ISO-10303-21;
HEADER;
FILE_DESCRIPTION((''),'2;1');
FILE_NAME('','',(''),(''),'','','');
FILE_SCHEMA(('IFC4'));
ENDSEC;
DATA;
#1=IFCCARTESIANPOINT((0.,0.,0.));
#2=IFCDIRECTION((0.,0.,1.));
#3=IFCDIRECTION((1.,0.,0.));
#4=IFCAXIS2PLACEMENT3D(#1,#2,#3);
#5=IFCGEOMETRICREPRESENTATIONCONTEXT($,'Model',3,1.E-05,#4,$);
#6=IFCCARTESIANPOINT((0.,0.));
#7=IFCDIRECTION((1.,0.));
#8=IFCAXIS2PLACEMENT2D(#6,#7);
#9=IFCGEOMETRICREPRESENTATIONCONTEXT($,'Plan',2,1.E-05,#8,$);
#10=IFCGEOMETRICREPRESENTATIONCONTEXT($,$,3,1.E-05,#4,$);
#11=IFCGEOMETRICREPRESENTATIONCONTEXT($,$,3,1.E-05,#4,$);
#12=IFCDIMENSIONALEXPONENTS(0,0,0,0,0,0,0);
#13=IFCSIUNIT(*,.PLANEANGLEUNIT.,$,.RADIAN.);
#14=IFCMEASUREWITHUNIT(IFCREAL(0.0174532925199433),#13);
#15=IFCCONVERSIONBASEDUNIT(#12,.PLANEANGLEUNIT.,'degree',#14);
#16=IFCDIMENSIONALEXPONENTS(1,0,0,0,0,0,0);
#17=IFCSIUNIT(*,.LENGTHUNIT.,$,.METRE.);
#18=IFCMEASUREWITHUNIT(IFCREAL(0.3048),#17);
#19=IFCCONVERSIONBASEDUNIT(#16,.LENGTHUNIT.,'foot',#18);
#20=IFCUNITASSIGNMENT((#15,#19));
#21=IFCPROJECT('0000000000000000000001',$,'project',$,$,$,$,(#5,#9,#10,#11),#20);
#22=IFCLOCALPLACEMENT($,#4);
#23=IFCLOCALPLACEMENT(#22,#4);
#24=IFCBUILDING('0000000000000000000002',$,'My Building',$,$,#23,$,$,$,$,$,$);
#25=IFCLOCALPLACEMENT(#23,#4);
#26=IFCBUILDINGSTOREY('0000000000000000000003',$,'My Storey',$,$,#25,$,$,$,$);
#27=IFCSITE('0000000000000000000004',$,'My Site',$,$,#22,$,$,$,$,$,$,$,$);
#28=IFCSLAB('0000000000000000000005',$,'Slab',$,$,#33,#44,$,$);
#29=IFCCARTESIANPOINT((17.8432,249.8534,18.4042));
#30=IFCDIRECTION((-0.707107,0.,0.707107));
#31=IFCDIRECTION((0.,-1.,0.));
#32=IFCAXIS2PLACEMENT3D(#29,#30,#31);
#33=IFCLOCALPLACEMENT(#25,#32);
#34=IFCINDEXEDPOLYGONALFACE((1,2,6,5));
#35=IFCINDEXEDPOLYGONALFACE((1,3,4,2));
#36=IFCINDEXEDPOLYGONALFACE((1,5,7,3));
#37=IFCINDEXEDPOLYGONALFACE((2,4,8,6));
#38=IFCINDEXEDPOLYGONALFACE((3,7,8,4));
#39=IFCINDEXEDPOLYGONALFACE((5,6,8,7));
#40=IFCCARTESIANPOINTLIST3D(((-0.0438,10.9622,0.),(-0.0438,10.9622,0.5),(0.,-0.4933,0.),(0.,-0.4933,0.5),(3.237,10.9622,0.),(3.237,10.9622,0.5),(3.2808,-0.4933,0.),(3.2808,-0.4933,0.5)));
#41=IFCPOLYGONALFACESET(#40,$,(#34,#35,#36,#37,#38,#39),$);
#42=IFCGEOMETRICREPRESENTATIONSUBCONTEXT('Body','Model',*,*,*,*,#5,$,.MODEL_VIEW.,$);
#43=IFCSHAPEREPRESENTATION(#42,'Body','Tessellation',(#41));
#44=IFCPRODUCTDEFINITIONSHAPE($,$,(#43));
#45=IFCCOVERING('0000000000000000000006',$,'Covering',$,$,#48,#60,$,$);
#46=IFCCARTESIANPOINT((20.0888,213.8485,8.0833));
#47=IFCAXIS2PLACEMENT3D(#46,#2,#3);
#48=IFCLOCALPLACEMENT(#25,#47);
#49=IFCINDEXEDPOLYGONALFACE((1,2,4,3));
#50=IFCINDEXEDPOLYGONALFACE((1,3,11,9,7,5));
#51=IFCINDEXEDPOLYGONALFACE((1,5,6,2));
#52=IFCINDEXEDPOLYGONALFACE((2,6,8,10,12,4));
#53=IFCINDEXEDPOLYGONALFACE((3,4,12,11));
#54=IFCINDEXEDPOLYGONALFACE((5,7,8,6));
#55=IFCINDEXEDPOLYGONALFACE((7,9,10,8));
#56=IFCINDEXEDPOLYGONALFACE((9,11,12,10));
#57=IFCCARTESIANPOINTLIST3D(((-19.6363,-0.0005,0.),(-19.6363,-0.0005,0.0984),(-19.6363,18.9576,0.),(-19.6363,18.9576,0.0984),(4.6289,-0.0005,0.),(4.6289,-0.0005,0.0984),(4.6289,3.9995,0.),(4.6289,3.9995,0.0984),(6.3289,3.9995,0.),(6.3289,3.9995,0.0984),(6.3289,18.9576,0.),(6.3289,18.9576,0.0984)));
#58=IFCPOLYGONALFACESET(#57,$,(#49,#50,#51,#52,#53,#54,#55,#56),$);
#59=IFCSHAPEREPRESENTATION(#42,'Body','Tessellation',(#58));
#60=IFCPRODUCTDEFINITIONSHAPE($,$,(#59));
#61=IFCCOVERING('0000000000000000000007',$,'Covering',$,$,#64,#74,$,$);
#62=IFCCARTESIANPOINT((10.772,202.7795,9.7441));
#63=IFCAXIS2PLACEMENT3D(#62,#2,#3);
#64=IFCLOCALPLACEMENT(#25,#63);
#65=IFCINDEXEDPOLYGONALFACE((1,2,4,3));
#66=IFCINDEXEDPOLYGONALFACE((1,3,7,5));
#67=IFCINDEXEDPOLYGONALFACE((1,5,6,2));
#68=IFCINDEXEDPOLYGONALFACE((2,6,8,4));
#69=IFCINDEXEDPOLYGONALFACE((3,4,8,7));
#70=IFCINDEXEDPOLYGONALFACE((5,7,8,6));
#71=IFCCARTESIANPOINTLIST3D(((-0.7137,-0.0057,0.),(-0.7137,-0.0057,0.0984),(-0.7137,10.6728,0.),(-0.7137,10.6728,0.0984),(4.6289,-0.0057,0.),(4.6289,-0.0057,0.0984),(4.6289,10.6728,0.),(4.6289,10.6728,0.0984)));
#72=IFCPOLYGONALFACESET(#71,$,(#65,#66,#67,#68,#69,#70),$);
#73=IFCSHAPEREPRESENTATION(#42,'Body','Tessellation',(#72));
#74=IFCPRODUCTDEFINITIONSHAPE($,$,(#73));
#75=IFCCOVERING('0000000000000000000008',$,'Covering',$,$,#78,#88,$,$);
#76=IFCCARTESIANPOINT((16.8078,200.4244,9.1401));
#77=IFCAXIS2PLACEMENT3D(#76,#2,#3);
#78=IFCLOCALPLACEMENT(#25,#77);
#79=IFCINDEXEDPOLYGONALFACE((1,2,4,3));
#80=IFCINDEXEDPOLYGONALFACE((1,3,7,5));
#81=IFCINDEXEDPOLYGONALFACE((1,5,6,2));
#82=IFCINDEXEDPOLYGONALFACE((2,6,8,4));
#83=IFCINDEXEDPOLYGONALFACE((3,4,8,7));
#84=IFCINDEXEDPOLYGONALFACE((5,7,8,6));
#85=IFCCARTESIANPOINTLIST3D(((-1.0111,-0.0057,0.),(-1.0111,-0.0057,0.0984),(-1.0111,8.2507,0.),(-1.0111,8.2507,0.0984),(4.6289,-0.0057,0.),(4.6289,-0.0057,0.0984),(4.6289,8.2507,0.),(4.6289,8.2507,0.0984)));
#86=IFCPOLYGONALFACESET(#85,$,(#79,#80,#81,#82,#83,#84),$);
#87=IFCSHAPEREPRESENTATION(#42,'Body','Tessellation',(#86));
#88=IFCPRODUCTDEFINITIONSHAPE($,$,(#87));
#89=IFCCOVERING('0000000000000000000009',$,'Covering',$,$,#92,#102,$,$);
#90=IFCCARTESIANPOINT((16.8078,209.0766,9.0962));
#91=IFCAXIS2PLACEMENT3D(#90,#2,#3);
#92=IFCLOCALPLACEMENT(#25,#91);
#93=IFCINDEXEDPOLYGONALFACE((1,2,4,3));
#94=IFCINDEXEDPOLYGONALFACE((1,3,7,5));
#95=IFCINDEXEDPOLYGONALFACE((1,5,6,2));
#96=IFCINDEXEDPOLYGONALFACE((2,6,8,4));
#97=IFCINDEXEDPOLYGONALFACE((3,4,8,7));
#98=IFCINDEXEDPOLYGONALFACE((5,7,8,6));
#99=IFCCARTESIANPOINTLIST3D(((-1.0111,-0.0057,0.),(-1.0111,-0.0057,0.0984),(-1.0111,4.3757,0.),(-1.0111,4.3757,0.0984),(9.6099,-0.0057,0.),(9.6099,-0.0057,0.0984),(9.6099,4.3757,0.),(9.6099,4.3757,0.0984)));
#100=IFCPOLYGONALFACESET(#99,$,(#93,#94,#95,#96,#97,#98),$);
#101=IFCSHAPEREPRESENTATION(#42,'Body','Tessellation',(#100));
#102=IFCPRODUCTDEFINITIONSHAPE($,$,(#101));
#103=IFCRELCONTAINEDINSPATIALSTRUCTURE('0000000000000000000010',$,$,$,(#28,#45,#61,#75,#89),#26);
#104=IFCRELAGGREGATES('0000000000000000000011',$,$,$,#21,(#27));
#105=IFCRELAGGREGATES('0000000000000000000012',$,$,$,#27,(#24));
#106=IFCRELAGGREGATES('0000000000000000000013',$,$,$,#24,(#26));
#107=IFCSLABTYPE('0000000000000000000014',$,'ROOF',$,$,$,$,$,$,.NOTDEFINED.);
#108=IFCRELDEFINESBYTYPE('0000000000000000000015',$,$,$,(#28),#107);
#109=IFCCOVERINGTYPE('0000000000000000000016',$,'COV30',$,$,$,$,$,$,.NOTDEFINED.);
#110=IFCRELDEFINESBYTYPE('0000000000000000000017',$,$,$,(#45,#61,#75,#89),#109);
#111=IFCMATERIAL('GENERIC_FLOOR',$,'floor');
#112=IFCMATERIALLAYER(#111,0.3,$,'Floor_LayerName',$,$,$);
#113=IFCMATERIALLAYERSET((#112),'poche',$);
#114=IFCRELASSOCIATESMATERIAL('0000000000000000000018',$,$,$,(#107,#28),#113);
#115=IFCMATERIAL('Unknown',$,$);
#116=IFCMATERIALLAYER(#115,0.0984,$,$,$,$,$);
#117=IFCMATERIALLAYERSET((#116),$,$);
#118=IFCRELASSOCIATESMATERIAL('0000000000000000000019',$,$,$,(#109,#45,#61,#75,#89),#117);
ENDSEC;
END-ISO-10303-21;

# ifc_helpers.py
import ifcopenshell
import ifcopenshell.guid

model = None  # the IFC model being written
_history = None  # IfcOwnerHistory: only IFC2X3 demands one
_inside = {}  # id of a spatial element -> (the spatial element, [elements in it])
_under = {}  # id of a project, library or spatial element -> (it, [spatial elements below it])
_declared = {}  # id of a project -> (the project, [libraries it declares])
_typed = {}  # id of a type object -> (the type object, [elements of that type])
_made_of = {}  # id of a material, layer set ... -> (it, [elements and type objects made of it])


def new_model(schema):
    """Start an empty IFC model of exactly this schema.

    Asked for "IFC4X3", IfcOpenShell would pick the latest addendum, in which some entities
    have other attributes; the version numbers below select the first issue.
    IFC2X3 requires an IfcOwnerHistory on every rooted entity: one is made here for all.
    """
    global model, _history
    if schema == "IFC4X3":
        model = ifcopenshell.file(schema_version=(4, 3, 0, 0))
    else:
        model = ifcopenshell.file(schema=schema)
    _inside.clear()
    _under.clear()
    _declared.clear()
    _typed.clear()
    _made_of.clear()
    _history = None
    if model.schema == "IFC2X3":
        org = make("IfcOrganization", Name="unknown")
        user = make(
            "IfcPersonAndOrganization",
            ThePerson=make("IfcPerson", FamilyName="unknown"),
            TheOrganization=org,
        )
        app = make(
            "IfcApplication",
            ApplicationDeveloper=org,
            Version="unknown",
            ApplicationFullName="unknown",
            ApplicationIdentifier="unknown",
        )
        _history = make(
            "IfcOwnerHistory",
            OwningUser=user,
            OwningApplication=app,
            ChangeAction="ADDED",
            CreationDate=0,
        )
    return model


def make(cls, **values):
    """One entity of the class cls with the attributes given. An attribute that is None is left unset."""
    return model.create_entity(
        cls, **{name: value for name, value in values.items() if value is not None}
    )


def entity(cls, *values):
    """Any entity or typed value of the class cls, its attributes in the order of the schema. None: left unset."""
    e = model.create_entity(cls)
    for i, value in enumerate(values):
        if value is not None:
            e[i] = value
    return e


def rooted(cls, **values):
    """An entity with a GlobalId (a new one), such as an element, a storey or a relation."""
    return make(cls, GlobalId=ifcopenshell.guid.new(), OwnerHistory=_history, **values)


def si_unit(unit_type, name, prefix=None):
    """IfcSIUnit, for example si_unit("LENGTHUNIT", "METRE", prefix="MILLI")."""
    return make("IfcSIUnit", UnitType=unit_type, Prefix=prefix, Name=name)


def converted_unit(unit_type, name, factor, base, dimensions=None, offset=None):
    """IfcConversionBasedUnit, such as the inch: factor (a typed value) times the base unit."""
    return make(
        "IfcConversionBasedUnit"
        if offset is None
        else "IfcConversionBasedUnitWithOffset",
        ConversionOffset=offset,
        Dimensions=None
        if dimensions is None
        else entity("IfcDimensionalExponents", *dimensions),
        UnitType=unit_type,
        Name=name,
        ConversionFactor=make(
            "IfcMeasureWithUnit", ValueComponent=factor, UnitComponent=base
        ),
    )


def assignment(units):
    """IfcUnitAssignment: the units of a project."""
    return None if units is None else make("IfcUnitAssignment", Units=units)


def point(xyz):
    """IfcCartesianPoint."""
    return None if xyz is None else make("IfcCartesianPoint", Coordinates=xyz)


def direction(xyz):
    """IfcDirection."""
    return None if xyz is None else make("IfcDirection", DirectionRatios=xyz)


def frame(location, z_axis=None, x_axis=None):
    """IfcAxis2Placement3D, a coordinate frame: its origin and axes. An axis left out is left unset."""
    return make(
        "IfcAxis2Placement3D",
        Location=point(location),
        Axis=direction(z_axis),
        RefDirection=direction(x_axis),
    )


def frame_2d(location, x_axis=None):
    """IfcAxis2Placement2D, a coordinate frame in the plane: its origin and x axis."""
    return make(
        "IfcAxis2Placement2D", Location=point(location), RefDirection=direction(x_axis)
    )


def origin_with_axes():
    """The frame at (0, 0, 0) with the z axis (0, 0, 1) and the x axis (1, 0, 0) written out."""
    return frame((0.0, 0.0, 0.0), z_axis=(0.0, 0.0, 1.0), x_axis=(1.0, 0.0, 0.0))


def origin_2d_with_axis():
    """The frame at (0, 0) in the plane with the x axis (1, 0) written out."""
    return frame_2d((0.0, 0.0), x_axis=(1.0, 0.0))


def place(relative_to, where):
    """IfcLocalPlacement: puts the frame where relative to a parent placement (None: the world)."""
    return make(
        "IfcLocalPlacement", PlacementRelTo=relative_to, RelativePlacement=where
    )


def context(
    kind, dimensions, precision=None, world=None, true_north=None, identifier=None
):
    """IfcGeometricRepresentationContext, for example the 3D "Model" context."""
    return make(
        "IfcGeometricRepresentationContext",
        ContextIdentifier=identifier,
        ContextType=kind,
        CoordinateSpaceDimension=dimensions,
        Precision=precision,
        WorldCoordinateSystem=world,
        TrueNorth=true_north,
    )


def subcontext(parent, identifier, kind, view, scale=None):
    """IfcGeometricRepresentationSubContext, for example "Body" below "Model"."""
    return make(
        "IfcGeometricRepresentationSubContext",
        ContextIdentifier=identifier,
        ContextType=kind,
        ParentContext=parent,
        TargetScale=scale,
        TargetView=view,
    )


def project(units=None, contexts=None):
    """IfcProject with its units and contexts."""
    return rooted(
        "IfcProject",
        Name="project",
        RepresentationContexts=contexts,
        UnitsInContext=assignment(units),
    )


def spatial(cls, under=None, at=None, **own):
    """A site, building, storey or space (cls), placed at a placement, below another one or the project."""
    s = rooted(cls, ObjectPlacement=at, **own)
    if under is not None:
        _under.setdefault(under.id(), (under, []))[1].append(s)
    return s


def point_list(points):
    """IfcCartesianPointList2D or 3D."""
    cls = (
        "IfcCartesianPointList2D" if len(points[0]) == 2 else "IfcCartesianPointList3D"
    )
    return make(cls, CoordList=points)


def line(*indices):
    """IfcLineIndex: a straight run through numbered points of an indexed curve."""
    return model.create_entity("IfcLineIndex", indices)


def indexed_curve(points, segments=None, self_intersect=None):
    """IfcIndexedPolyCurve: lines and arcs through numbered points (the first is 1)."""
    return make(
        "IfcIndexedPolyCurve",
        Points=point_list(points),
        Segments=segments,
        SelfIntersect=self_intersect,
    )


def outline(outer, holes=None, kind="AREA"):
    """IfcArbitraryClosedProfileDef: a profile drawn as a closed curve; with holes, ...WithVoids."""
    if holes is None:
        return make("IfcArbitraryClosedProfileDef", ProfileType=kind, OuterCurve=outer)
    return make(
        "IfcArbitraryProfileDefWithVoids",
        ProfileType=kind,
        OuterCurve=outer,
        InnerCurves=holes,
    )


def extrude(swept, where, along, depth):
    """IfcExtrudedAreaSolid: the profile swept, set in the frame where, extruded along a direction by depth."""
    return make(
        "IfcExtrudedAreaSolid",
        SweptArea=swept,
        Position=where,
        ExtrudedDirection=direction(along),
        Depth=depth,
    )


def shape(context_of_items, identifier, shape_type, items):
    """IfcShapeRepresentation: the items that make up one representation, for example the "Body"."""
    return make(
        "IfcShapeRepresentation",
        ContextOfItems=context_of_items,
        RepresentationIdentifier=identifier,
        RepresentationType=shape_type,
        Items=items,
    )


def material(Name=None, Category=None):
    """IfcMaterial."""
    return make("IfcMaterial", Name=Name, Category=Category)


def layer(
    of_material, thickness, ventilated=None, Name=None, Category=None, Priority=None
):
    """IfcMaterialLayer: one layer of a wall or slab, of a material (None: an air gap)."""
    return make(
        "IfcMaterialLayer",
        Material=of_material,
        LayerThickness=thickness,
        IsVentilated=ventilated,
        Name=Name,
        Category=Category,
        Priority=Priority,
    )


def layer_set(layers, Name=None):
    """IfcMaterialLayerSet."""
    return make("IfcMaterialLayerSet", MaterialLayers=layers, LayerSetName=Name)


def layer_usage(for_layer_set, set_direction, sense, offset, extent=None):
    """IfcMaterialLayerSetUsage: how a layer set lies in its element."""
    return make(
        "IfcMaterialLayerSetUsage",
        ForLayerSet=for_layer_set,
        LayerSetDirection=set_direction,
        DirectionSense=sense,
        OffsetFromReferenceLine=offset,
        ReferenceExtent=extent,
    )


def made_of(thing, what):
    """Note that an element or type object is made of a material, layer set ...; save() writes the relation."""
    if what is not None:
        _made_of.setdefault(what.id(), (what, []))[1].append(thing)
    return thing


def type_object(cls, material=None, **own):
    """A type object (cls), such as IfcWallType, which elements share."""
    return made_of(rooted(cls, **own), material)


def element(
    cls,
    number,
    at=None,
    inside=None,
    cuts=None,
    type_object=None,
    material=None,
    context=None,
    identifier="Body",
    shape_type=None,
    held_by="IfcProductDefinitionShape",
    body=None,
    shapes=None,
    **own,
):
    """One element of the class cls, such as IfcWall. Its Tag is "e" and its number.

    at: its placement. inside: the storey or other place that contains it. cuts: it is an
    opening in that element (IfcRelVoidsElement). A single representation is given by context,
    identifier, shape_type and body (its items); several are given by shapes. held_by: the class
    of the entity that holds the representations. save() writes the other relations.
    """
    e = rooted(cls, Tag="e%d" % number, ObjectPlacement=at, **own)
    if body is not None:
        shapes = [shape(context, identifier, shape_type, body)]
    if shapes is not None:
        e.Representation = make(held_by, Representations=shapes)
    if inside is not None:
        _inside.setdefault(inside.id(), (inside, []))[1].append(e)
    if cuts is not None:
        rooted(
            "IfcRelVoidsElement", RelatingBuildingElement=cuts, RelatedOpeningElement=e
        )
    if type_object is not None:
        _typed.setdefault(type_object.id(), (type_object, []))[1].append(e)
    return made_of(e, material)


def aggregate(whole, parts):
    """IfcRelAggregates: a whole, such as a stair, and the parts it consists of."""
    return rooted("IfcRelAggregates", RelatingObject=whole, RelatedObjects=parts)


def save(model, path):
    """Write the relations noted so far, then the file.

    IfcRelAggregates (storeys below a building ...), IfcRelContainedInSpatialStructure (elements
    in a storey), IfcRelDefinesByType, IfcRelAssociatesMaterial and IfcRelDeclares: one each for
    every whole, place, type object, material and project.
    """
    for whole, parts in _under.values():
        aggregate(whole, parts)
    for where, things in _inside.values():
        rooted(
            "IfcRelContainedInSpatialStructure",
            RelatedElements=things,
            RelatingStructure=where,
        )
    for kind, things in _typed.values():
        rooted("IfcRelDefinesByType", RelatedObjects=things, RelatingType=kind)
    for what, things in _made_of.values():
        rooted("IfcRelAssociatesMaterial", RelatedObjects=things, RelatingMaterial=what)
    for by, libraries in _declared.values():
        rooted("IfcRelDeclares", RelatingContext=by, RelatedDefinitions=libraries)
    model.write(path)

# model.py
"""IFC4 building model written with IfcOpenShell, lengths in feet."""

from ifc_helpers import new_model, entity, si_unit, converted_unit, frame, origin_with_axes, origin_2d_with_axis, place, context, subcontext, project, spatial, line, indexed_curve, outline, extrude, material, layer, layer_set, layer_usage, type_object, element, save


model = new_model("IFC4")

# Units and contexts
model_context = context("Model", 3, precision=1e-05, world=origin_with_axes())
plan_context = context("Plan", 2, precision=1e-05, world=origin_2d_with_axis())
context_of_model_1 = context(None, 3, precision=1e-05, world=origin_with_axes())
context_of_model_2 = context(None, 3, precision=1e-05, world=origin_with_axes())
body_context = subcontext(model_context, "Body", "Model", "MODEL_VIEW")
ifc_project = project(units=[converted_unit("PLANEANGLEUNIT", "degree", entity("IfcReal", 0.0174532925199433), si_unit("PLANEANGLEUNIT", "RADIAN"), dimensions=[0, 0, 0, 0, 0, 0, 0]), converted_unit("LENGTHUNIT", "foot", entity("IfcReal", 0.3048), si_unit("LENGTHUNIT", "METRE"), dimensions=[1, 0, 0, 0, 0, 0, 0])], contexts=[model_context, plan_context, context_of_model_1, context_of_model_2])

# Site, building, storey
site_placement = place(None, origin_with_axes())
site = spatial("IfcSite", under=ifc_project, at=site_placement, Name="My Site")
building_placement = place(site_placement, origin_with_axes())
building = spatial("IfcBuilding", under=site, at=building_placement, Name="My Building")
storey_placement = place(building_placement, origin_with_axes())
storey = spatial("IfcBuildingStorey", under=building, at=storey_placement, Name="My Storey")

# Slab
ifc_material_1 = material(Name="GENERIC_FLOOR", Category="floor")
ifc_layer_1 = layer(ifc_material_1, 0.3, Name="Floor_LayerName")
ifc_layer_set_1 = layer_set([ifc_layer_1], Name="poche")
ifc_layer_usage_1 = layer_usage(ifc_layer_set_1, "AXIS3", "POSITIVE", 0.0)
slab_type = type_object("IfcSlabType", Name="ROOF", PredefinedType="NOTDEFINED", material=ifc_layer_set_1)
slab_placement = place(storey_placement, frame((17.8432, 249.8534, 18.4042), z_axis=(-0.707107, 0.0, 0.707107), x_axis=(0.0, -1.0, 0.0)))
element("IfcSlab", 1, at=slab_placement, inside=storey, type_object=slab_type, material=ifc_layer_usage_1, Name="Slab", context=body_context, shape_type="SweptSolid", body=[
    extrude(outline(indexed_curve([(3.237, 10.9622), (-0.0438, 10.9622), (0.0, -0.4933), (3.2808, -0.4933)], segments=[line(4, 1), line(1, 2), line(2, 3), line(3, 4)], self_intersect=False)), None, (0.0, 0.0, 1.0), 0.5),
])

# Coverings
ifc_material_2 = material(Name="Unknown")
ifc_layer_2 = layer(ifc_material_2, 0.0984)
ifc_layer_set_2 = layer_set([ifc_layer_2])
ifc_layer_usage_2 = layer_usage(ifc_layer_set_2, "AXIS3", "POSITIVE", 0.0)
covering_type = type_object("IfcCoveringType", Name="COV30", PredefinedType="NOTDEFINED", material=ifc_layer_set_2)
covering_1_placement = place(storey_placement, frame((20.0888, 213.8485, 8.0833), z_axis=(0.0, 0.0, 1.0), x_axis=(1.0, 0.0, 0.0)))
element("IfcCovering", 2, at=covering_1_placement, inside=storey, type_object=covering_type, material=ifc_layer_usage_2, Name="Covering", context=body_context, shape_type="SweptSolid", body=[
    extrude(outline(indexed_curve([(6.3289, 3.9995), (6.3289, 18.9576), (-19.6363, 18.9576), (-19.6363, -0.0005), (4.6289, -0.0005), (4.6289, 3.9995)], segments=[line(5, 4), line(4, 3), line(3, 2), line(2, 1), line(1, 6), line(6, 5)], self_intersect=False)), None, (0.0, 0.0, 1.0), 0.0984),
])
ifc_layer_usage_3 = layer_usage(ifc_layer_set_2, "AXIS3", "POSITIVE", 0.0)
covering_2_placement = place(storey_placement, frame((10.772, 202.7795, 9.7441), z_axis=(0.0, 0.0, 1.0), x_axis=(1.0, 0.0, 0.0)))
element("IfcCovering", 3, at=covering_2_placement, inside=storey, type_object=covering_type, material=ifc_layer_usage_3, Name="Covering", context=body_context, shape_type="SweptSolid", body=[
    extrude(outline(indexed_curve([(4.6289, -0.0057), (4.6289, 10.6728), (-0.7137, 10.6728), (-0.7137, -0.0057)], segments=[line(3, 2), line(2, 1), line(1, 4), line(4, 3)], self_intersect=False)), None, (0.0, 0.0, 1.0), 0.0984),
])
ifc_layer_usage_4 = layer_usage(ifc_layer_set_2, "AXIS3", "POSITIVE", 0.0)
covering_3_placement = place(storey_placement, frame((16.8078, 200.4244, 9.1401), z_axis=(0.0, 0.0, 1.0), x_axis=(1.0, 0.0, 0.0)))
element("IfcCovering", 4, at=covering_3_placement, inside=storey, type_object=covering_type, material=ifc_layer_usage_4, Name="Covering", context=body_context, shape_type="SweptSolid", body=[
    extrude(outline(indexed_curve([(-1.0111, 8.2507), (4.6289, 8.2507), (4.6289, -0.0057), (-1.0111, -0.0057)], segments=[line(3, 2), line(2, 1), line(1, 4), line(4, 3)], self_intersect=False)), None, (0.0, 0.0, 1.0), 0.0984),
])
ifc_layer_usage_5 = layer_usage(ifc_layer_set_2, "AXIS3", "POSITIVE", 0.0)
covering_4_placement = place(storey_placement, frame((16.8078, 209.0766, 9.0962), z_axis=(0.0, 0.0, 1.0), x_axis=(1.0, 0.0, 0.0)))
element("IfcCovering", 5, at=covering_4_placement, inside=storey, type_object=covering_type, material=ifc_layer_usage_5, Name="Covering", context=body_context, shape_type="SweptSolid", body=[
    extrude(outline(indexed_curve([(9.6099, -0.0057), (9.6099, 4.3757), (-1.0111, 4.3757), (-1.0111, -0.0057)], segments=[line(3, 2), line(2, 1), line(1, 4), line(4, 3)], self_intersect=False)), None, (0.0, 0.0, 1.0), 0.0984),
])

save(model, "model.ifc")
